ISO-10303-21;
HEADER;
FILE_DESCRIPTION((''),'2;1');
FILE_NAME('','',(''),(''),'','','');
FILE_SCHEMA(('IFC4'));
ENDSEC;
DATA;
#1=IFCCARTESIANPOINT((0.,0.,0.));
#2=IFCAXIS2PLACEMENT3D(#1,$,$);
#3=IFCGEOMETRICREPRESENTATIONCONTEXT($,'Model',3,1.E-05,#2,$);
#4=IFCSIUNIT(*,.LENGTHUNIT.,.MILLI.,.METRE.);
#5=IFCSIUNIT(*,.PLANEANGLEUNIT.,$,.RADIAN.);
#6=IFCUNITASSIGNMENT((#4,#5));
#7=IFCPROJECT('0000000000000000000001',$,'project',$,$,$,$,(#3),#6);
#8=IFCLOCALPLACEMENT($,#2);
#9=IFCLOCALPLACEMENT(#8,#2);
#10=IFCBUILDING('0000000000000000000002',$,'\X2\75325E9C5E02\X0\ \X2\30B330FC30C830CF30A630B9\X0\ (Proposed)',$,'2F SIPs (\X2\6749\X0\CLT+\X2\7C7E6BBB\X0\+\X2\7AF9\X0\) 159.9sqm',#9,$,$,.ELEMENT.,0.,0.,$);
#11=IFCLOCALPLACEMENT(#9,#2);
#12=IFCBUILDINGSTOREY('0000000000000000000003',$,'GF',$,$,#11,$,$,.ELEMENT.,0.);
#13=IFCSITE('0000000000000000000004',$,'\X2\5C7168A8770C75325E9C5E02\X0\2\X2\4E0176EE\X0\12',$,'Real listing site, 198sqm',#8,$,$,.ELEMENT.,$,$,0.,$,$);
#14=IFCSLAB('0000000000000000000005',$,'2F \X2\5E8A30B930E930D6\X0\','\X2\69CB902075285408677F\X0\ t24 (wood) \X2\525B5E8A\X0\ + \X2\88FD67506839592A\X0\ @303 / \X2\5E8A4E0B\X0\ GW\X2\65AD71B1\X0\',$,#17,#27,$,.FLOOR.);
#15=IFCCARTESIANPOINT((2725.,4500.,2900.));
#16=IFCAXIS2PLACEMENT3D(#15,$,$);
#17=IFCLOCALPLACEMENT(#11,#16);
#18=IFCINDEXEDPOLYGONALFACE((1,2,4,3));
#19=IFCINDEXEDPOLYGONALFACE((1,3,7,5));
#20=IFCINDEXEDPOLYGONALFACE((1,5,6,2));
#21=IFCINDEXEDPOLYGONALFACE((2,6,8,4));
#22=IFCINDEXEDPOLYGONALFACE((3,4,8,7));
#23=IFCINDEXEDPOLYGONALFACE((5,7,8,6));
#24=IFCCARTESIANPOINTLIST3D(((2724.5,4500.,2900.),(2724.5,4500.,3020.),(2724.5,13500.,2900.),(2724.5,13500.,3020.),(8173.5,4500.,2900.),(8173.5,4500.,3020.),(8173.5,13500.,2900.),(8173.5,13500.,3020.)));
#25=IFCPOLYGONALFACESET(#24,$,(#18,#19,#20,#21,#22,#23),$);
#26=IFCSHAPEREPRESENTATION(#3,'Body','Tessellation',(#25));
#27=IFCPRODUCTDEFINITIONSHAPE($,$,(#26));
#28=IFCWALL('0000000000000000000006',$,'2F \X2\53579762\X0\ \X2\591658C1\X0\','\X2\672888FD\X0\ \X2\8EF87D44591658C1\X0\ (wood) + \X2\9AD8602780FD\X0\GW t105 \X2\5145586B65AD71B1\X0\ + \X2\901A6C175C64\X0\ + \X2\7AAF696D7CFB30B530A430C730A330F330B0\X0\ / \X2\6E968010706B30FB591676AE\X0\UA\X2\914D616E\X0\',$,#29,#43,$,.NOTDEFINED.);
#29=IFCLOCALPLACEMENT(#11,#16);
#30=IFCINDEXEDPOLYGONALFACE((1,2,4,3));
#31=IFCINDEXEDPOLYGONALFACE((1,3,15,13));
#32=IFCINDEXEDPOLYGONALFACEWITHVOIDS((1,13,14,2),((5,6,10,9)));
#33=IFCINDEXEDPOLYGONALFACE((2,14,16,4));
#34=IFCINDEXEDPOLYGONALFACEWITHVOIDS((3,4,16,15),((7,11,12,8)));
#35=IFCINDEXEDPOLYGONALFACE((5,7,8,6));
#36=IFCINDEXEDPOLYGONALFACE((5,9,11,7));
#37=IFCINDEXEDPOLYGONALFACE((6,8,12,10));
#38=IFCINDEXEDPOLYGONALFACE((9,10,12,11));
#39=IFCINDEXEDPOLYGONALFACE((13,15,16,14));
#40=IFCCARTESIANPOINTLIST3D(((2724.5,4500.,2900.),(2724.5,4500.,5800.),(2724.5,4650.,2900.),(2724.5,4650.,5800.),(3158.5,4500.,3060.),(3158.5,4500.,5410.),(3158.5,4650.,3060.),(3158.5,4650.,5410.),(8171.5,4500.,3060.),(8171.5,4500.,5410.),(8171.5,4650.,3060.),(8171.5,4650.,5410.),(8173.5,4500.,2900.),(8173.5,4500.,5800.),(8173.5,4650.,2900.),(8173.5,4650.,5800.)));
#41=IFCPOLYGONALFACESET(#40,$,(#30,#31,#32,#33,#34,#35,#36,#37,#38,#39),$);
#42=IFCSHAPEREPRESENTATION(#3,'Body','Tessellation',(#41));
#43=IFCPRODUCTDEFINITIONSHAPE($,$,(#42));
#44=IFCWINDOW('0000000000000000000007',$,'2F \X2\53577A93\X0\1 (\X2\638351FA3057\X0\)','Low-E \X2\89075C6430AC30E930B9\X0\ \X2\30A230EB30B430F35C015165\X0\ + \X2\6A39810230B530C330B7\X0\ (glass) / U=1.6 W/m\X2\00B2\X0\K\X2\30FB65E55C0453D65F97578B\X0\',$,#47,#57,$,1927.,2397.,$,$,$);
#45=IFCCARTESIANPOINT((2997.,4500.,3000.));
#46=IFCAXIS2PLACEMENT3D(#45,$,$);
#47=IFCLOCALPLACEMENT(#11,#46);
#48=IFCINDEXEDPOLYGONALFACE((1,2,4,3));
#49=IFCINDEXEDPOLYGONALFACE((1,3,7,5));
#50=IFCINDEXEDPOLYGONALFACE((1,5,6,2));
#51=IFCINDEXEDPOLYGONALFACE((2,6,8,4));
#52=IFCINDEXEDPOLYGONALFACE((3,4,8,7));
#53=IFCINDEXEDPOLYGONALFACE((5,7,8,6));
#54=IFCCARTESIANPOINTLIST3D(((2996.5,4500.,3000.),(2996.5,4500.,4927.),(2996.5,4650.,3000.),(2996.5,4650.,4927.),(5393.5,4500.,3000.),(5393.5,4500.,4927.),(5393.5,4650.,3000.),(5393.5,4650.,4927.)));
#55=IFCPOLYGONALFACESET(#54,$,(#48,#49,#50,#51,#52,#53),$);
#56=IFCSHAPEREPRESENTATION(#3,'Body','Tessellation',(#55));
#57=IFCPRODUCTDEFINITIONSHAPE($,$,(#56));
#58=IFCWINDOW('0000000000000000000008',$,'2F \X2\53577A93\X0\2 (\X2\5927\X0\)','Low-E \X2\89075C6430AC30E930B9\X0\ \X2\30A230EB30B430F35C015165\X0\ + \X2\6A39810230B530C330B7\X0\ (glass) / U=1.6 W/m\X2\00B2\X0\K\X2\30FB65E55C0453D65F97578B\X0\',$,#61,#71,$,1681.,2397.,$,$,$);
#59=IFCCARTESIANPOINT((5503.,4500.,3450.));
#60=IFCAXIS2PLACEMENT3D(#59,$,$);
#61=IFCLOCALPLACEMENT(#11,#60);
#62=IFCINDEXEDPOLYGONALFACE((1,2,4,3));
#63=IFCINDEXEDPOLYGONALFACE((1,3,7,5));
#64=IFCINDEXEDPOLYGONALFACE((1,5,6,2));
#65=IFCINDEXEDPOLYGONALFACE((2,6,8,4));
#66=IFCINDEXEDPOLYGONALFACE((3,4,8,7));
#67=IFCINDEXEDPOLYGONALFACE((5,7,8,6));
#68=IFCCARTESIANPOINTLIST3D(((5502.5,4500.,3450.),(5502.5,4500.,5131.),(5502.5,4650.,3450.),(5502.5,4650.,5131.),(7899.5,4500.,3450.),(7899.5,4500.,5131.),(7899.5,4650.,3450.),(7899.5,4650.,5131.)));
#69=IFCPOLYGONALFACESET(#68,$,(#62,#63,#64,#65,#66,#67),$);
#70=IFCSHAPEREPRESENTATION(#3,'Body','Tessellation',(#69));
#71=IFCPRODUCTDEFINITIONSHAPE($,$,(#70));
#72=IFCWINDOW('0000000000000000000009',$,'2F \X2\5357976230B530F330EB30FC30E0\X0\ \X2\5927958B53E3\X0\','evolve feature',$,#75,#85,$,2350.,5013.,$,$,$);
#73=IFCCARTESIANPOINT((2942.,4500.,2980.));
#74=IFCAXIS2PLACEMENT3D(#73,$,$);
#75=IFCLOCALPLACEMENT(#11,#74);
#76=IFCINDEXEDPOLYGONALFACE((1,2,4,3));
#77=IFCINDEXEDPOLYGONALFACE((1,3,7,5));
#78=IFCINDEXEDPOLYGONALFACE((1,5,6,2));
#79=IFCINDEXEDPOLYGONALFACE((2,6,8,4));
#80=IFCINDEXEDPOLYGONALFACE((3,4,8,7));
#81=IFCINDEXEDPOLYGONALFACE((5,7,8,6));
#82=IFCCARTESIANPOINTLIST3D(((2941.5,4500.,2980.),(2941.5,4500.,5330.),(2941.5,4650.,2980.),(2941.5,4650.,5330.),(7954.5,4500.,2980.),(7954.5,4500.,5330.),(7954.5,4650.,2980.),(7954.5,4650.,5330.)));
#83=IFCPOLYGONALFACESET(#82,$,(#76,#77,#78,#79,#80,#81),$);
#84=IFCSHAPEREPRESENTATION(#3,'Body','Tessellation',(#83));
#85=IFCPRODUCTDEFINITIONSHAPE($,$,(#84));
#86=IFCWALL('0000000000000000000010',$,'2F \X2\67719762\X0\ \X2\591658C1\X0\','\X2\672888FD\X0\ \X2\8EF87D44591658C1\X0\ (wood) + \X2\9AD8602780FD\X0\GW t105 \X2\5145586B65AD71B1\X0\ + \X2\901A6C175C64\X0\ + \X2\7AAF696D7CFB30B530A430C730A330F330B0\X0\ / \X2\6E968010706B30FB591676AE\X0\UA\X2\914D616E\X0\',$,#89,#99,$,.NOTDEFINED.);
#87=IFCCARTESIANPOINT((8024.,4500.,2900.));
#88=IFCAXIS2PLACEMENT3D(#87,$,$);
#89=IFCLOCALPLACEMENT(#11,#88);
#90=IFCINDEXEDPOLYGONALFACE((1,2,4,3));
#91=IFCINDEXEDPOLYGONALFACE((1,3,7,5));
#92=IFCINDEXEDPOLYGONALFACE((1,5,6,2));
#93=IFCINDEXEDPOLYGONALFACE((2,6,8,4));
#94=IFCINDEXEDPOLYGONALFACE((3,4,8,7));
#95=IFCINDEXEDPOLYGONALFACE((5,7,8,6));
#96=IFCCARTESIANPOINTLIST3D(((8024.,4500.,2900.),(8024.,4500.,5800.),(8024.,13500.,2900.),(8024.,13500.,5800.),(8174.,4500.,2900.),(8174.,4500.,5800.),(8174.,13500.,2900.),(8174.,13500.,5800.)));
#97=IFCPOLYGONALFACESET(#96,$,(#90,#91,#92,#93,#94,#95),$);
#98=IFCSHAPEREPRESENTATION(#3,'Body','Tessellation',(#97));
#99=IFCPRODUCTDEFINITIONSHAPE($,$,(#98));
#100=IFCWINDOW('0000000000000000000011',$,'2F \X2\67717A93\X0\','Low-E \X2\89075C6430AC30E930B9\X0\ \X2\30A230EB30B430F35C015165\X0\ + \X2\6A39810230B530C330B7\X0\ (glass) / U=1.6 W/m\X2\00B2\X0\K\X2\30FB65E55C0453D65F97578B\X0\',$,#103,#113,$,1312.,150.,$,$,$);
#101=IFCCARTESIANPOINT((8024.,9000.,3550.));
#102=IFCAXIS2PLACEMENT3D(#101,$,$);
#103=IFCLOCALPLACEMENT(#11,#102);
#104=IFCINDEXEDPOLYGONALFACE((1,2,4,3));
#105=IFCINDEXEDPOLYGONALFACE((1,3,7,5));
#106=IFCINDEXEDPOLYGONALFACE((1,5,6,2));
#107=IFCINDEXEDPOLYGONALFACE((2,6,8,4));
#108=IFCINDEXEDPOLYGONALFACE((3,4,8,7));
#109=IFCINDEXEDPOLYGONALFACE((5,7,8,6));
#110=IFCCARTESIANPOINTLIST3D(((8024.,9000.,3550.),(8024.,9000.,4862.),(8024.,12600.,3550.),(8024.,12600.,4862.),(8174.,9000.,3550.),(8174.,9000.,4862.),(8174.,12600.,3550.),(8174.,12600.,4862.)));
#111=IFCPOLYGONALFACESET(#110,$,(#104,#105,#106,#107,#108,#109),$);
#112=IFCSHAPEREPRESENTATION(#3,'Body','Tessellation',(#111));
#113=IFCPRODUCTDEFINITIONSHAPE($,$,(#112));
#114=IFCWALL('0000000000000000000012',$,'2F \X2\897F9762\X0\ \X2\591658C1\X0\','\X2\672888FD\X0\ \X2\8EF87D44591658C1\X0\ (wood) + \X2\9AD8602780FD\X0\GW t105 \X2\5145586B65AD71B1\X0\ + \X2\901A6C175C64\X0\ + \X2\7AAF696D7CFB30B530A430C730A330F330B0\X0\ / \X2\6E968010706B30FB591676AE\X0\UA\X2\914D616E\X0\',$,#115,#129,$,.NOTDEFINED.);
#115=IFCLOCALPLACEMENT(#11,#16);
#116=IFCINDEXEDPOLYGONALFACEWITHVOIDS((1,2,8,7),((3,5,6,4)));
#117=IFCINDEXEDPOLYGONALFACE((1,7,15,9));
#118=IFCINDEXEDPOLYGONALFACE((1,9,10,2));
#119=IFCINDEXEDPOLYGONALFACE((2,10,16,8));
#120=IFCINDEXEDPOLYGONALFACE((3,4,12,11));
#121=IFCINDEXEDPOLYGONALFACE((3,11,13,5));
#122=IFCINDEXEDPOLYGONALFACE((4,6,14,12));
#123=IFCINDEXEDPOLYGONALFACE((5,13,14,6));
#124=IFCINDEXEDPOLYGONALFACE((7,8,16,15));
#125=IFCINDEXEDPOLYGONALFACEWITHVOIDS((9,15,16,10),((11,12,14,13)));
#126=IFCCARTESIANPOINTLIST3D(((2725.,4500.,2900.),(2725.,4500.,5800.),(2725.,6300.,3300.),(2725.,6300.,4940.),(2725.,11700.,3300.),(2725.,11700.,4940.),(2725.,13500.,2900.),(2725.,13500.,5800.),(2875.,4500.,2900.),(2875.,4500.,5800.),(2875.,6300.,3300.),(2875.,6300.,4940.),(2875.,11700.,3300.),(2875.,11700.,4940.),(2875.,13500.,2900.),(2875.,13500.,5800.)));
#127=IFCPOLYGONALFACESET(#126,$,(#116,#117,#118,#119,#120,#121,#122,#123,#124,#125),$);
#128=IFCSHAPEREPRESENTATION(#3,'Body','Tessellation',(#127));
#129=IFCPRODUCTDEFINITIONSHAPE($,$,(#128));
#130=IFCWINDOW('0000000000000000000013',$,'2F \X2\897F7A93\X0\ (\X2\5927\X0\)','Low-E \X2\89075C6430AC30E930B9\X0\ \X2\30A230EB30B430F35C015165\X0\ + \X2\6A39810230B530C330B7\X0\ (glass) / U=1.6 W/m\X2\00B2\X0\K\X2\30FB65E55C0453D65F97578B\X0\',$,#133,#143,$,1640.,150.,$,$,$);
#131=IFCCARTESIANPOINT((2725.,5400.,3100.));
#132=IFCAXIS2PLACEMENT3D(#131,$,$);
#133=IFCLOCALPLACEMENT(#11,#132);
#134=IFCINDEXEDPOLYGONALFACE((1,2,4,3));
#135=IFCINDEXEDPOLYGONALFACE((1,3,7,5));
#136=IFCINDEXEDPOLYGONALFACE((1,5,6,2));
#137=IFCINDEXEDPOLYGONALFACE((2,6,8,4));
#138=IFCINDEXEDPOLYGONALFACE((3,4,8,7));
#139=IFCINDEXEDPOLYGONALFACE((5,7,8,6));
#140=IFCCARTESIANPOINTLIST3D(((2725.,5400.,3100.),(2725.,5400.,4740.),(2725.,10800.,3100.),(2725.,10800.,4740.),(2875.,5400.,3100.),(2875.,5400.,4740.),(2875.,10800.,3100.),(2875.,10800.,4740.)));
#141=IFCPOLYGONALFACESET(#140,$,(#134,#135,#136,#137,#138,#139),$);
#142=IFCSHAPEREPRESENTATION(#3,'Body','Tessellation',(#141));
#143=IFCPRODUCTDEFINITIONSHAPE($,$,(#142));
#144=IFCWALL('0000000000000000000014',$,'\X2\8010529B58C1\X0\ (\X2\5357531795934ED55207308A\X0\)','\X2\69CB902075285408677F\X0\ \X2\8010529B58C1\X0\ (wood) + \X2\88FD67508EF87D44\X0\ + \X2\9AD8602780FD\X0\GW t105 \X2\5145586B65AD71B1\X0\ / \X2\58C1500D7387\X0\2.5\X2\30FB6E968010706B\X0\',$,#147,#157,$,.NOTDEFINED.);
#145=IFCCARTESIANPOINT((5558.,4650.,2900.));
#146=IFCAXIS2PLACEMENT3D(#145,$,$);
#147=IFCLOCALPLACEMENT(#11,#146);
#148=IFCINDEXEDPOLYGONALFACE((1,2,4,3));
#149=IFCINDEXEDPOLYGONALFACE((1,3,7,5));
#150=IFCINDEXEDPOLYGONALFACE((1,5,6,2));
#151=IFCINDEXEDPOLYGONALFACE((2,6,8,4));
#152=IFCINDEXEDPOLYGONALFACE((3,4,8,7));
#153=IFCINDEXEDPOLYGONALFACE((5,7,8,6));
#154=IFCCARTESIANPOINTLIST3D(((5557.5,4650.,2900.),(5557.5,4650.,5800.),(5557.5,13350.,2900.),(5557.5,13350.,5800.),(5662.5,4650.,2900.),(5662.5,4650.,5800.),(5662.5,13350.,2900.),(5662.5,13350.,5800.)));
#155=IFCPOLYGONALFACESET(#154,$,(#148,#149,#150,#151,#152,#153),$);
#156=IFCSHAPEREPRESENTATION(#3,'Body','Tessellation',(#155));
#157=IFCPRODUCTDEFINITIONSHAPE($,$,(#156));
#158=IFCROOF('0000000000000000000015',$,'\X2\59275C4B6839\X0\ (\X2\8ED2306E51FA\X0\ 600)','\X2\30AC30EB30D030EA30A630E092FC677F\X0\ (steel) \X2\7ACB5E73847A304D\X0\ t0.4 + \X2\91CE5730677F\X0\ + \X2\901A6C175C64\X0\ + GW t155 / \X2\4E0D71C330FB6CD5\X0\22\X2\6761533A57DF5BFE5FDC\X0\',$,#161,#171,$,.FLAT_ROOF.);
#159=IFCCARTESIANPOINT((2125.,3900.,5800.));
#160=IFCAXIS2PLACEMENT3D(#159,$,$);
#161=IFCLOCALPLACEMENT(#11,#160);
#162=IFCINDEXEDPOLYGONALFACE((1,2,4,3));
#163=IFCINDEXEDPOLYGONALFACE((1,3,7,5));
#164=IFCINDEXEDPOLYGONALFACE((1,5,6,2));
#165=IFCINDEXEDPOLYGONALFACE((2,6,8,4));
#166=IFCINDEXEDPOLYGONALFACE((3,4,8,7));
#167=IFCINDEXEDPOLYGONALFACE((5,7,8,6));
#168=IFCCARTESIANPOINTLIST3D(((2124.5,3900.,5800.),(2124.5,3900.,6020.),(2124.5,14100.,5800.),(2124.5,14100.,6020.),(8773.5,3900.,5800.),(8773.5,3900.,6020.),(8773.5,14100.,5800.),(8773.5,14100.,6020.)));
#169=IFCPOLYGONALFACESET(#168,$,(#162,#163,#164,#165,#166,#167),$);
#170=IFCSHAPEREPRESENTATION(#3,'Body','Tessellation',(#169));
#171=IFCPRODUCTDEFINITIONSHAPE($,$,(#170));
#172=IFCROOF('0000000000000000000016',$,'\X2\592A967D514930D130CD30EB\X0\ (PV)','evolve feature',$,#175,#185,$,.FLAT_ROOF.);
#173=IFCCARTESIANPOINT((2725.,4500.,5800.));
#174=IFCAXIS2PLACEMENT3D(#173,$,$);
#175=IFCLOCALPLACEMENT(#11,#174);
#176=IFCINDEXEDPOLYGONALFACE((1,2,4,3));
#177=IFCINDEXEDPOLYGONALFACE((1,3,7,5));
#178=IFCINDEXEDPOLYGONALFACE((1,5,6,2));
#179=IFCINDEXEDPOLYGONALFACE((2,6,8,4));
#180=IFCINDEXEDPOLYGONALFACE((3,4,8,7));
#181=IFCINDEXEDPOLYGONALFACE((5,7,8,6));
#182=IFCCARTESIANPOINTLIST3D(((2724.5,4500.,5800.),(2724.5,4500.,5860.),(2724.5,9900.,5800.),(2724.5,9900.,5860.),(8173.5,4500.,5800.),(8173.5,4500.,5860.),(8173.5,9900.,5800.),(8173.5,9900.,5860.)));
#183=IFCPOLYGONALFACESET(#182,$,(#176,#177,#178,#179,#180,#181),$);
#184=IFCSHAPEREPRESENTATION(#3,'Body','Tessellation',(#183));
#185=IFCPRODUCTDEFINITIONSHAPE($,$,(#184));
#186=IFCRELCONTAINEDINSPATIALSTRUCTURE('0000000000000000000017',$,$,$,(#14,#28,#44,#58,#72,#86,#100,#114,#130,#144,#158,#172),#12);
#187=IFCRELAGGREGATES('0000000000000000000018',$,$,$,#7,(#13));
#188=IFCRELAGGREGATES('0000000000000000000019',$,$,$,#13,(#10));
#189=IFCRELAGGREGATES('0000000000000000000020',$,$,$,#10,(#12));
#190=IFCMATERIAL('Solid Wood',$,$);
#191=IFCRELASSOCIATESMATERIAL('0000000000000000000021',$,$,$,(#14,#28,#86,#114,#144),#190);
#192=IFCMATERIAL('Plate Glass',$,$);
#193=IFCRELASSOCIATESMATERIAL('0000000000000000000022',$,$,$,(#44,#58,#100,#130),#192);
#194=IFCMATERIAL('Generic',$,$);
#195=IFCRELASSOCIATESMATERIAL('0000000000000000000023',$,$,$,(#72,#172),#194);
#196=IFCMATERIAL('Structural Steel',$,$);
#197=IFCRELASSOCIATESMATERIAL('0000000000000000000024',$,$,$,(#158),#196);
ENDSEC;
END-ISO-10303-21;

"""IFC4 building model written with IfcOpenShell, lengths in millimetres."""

from ifc_helpers import new_model, si_unit, frame, frame_2d, origin, place, context, project, spatial, rectangle, extrude, material, element, fill, save


model = new_model("IFC4")

# Units and contexts
model_context = context("Model", 3, precision=1e-05, world=origin())
ifc_project = project(units=[si_unit("LENGTHUNIT", "METRE", prefix="MILLI"), si_unit("PLANEANGLEUNIT", "RADIAN")], contexts=[model_context])

# Site, building, storey
site_placement = place(None, origin())
site = spatial("IfcSite", under=ifc_project, at=site_placement, Name="山梨県甲府市2丁目12", ObjectType="Real listing site, 198sqm", CompositionType="ELEMENT", RefElevation=0.0)
building_placement = place(site_placement, origin())
building = spatial("IfcBuilding", under=site, at=building_placement, Name="甲府市 コートハウス (Proposed)", ObjectType="2F SIPs (杉CLT+籾殻+竹) 159.9sqm", CompositionType="ELEMENT", ElevationOfRefHeight=0.0, ElevationOfTerrain=0.0)
storey_placement = place(building_placement, origin())
storey = spatial("IfcBuildingStorey", under=building, at=storey_placement, Name="GF", CompositionType="ELEMENT", Elevation=0.0)

# Slab
ifc_material_1 = material(Name="Solid Wood")
slab_placement = place(storey_placement, frame((2725.0, 4500.0, 2900.0)))
element("IfcSlab", 1, at=slab_placement, inside=storey, material=ifc_material_1, Name="2F 床スラブ", Description="構造用合板 t24 (wood) 剛床 + 製材根太 @303 / 床下 GW断熱", PredefinedType="FLOOR", context=model_context, shape_type="SweptSolid", body=[
    extrude(rectangle(XDim=5449.0, YDim=9000.0, at=frame_2d((2724.0, 4500.0))), frame((2725.0, 4500.0, 2900.0)), (0.0, 0.0, 1.0), 120.0),
])

# Wall, openings, windows
wall_1_placement = place(storey_placement, frame((2725.0, 4500.0, 2900.0)))
wall_1 = element("IfcWall", 2, at=wall_1_placement, inside=storey, material=ifc_material_1, Name="2F 南面 外壁", Description="木製 軸組外壁 (wood) + 高性能GW t105 充填断熱 + 通気層 + 窯業系サイディング / 準耐火・外皮UA配慮", PredefinedType="NOTDEFINED", context=model_context, shape_type="SweptSolid", body=[
    extrude(rectangle(XDim=5449.0, YDim=150.0, at=frame_2d((2724.0, 75.0))), frame((2725.0, 4500.0, 2900.0)), (0.0, 0.0, 1.0), 2900.0),
])
opening_1_placement = place(storey_placement, frame((2997.0, 4500.0, 3000.0)))
opening_1 = element("IfcOpeningElement", 3, at=opening_1_placement, cuts=wall_1, PredefinedType="NOTDEFINED", context=model_context, shape_type="SweptSolid", body=[
    extrude(rectangle(XDim=2397.0, YDim=150.0, at=frame_2d((1198.0, 75.0))), frame((2997.0, 4500.0, 3000.0)), (0.0, 0.0, 1.0), 1927.0),
])
opening_2_placement = place(storey_placement, frame((5503.0, 4500.0, 3450.0)))
opening_2 = element("IfcOpeningElement", 4, at=opening_2_placement, cuts=wall_1, PredefinedType="NOTDEFINED", context=model_context, shape_type="SweptSolid", body=[
    extrude(rectangle(XDim=2397.0, YDim=150.0, at=frame_2d((1198.0, 75.0))), frame((5503.0, 4500.0, 3450.0)), (0.0, 0.0, 1.0), 1681.0),
])
opening_3_placement = place(storey_placement, frame((2942.0, 4500.0, 2980.0)))
opening_3 = element("IfcOpeningElement", 5, at=opening_3_placement, cuts=wall_1, PredefinedType="NOTDEFINED", context=model_context, shape_type="SweptSolid", body=[
    extrude(rectangle(XDim=5013.0, YDim=150.0, at=frame_2d((2506.0, 75.0))), frame((2942.0, 4500.0, 2980.0)), (0.0, 0.0, 1.0), 2350.0),
])
ifc_material_2 = material(Name="Plate Glass")
window_1_placement = place(storey_placement, frame((2997.0, 4500.0, 3000.0)))
window_1 = element("IfcWindow", 6, at=window_1_placement, inside=storey, material=ifc_material_2, Name="2F 南窓1 (掃出し)", Description="Low-E 複層ガラス アルゴン封入 + 樹脂サッシ (glass) / U=1.6 W/m²K・日射取得型", OverallHeight=1927.0, OverallWidth=2397.0, context=model_context, shape_type="SweptSolid", body=[
    extrude(rectangle(XDim=2397.0, YDim=150.0, at=frame_2d((1198.0, 75.0))), frame((2997.0, 4500.0, 3000.0)), (0.0, 0.0, 1.0), 1927.0),
])
fill(opening_1, window_1)
window_2_placement = place(storey_placement, frame((5503.0, 4500.0, 3450.0)))
window_2 = element("IfcWindow", 7, at=window_2_placement, inside=storey, material=ifc_material_2, Name="2F 南窓2 (大)", Description="Low-E 複層ガラス アルゴン封入 + 樹脂サッシ (glass) / U=1.6 W/m²K・日射取得型", OverallHeight=1681.0, OverallWidth=2397.0, context=model_context, shape_type="SweptSolid", body=[
    extrude(rectangle(XDim=2397.0, YDim=150.0, at=frame_2d((1198.0, 75.0))), frame((5503.0, 4500.0, 3450.0)), (0.0, 0.0, 1.0), 1681.0),
])
fill(opening_2, window_2)
ifc_material_3 = material(Name="Generic")
window_3_placement = place(storey_placement, frame((2942.0, 4500.0, 2980.0)))
window_3 = element("IfcWindow", 8, at=window_3_placement, inside=storey, material=ifc_material_3, Name="2F 南面サンルーム 大開口", Description="evolve feature", OverallHeight=2350.0, OverallWidth=5013.0, context=model_context, shape_type="SweptSolid", body=[
    extrude(rectangle(XDim=5013.0, YDim=150.0, at=frame_2d((2506.0, 75.0))), frame((2942.0, 4500.0, 2980.0)), (0.0, 0.0, 1.0), 2350.0),
])
fill(opening_3, window_3)

# Walls, openings, windows
wall_2_placement = place(storey_placement, frame((8024.0, 4500.0, 2900.0)))
wall_2 = element("IfcWall", 9, at=wall_2_placement, inside=storey, material=ifc_material_1, Name="2F 東面 外壁", Description="木製 軸組外壁 (wood) + 高性能GW t105 充填断熱 + 通気層 + 窯業系サイディング / 準耐火・外皮UA配慮", PredefinedType="NOTDEFINED", context=model_context, shape_type="SweptSolid", body=[
    extrude(rectangle(XDim=150.0, YDim=9000.0, at=frame_2d((75.0, 4500.0))), frame((8024.0, 4500.0, 2900.0)), (0.0, 0.0, 1.0), 2900.0),
])
opening_4_placement = place(storey_placement, frame((8024.0, 9000.0, 3550.0)))
opening_4 = element("IfcOpeningElement", 10, at=opening_4_placement, cuts=wall_2, PredefinedType="NOTDEFINED", context=model_context, shape_type="SweptSolid", body=[
    extrude(rectangle(XDim=150.0, YDim=3600.0, at=frame_2d((75.0, 1800.0))), frame((8024.0, 9000.0, 3550.0)), (0.0, 0.0, 1.0), 1312.0),
])
window_4_placement = place(storey_placement, frame((8024.0, 9000.0, 3550.0)))
window_4 = element("IfcWindow", 11, at=window_4_placement, inside=storey, material=ifc_material_2, Name="2F 東窓", Description="Low-E 複層ガラス アルゴン封入 + 樹脂サッシ (glass) / U=1.6 W/m²K・日射取得型", OverallHeight=1312.0, OverallWidth=150.0, context=model_context, shape_type="SweptSolid", body=[
    extrude(rectangle(XDim=150.0, YDim=3600.0, at=frame_2d((75.0, 1800.0))), frame((8024.0, 9000.0, 3550.0)), (0.0, 0.0, 1.0), 1312.0),
])
fill(opening_4, window_4)
wall_3_placement = place(storey_placement, frame((2725.0, 4500.0, 2900.0)))
wall_3 = element("IfcWall", 12, at=wall_3_placement, inside=storey, material=ifc_material_1, Name="2F 西面 外壁", Description="木製 軸組外壁 (wood) + 高性能GW t105 充填断熱 + 通気層 + 窯業系サイディング / 準耐火・外皮UA配慮", PredefinedType="NOTDEFINED", context=model_context, shape_type="SweptSolid", body=[
    extrude(rectangle(XDim=150.0, YDim=9000.0, at=frame_2d((75.0, 4500.0))), frame((2725.0, 4500.0, 2900.0)), (0.0, 0.0, 1.0), 2900.0),
])
opening_5_placement = place(storey_placement, frame((2725.0, 5400.0, 3100.0)))
opening_5 = element("IfcOpeningElement", 13, at=opening_5_placement, cuts=wall_3, PredefinedType="NOTDEFINED", context=model_context, shape_type="SweptSolid", body=[
    extrude(rectangle(XDim=150.0, YDim=5400.0, at=frame_2d((75.0, 2700.0))), frame((2725.0, 5400.0, 3100.0)), (0.0, 0.0, 1.0), 1640.0),
])
window_5_placement = place(storey_placement, frame((2725.0, 5400.0, 3100.0)))
window_5 = element("IfcWindow", 14, at=window_5_placement, inside=storey, material=ifc_material_2, Name="2F 西窓 (大)", Description="Low-E 複層ガラス アルゴン封入 + 樹脂サッシ (glass) / U=1.6 W/m²K・日射取得型", OverallHeight=1640.0, OverallWidth=150.0, context=model_context, shape_type="SweptSolid", body=[
    extrude(rectangle(XDim=150.0, YDim=5400.0, at=frame_2d((75.0, 2700.0))), frame((2725.0, 5400.0, 3100.0)), (0.0, 0.0, 1.0), 1640.0),
])
fill(opening_5, window_5)

# Wall
wall_4_placement = place(storey_placement, frame((5558.0, 4650.0, 2900.0)))
element("IfcWall", 15, at=wall_4_placement, inside=storey, material=ifc_material_1, Name="耐力壁 (南北間仕切り)", Description="構造用合板 耐力壁 (wood) + 製材軸組 + 高性能GW t105 充填断熱 / 壁倍率2.5・準耐火", PredefinedType="NOTDEFINED", context=model_context, shape_type="SweptSolid", body=[
    extrude(rectangle(XDim=105.0, YDim=8700.0, at=frame_2d((52.0, 4350.0))), frame((5558.0, 4650.0, 2900.0)), (0.0, 0.0, 1.0), 2900.0),
])

# Roofs
ifc_material_4 = material(Name="Structural Steel")
roof_1_placement = place(storey_placement, frame((2125.0, 3900.0, 5800.0)))
element("IfcRoof", 16, at=roof_1_placement, inside=storey, material=ifc_material_4, Name="大屋根 (軒の出 600)", Description="ガルバリウム鋼板 (steel) 立平葺き t0.4 + 野地板 + 通気層 + GW t155 / 不燃・法22条区域対応", PredefinedType="FLAT_ROOF", context=model_context, shape_type="SweptSolid", body=[
    extrude(rectangle(XDim=6649.0, YDim=10200.0, at=frame_2d((3324.0, 5100.0))), frame((2125.0, 3900.0, 5800.0)), (0.0, 0.0, 1.0), 220.0),
])
roof_2_placement = place(storey_placement, frame((2725.0, 4500.0, 5800.0)))
element("IfcRoof", 17, at=roof_2_placement, inside=storey, material=ifc_material_3, Name="太陽光パネル (PV)", Description="evolve feature", PredefinedType="FLAT_ROOF", context=model_context, shape_type="SweptSolid", body=[
    extrude(rectangle(XDim=5449.0, YDim=5400.0, at=frame_2d((2724.0, 2700.0))), frame((2725.0, 4500.0, 5800.0)), (0.0, 0.0, 1.0), 60.0),
])

save(model, "model.ifc")
